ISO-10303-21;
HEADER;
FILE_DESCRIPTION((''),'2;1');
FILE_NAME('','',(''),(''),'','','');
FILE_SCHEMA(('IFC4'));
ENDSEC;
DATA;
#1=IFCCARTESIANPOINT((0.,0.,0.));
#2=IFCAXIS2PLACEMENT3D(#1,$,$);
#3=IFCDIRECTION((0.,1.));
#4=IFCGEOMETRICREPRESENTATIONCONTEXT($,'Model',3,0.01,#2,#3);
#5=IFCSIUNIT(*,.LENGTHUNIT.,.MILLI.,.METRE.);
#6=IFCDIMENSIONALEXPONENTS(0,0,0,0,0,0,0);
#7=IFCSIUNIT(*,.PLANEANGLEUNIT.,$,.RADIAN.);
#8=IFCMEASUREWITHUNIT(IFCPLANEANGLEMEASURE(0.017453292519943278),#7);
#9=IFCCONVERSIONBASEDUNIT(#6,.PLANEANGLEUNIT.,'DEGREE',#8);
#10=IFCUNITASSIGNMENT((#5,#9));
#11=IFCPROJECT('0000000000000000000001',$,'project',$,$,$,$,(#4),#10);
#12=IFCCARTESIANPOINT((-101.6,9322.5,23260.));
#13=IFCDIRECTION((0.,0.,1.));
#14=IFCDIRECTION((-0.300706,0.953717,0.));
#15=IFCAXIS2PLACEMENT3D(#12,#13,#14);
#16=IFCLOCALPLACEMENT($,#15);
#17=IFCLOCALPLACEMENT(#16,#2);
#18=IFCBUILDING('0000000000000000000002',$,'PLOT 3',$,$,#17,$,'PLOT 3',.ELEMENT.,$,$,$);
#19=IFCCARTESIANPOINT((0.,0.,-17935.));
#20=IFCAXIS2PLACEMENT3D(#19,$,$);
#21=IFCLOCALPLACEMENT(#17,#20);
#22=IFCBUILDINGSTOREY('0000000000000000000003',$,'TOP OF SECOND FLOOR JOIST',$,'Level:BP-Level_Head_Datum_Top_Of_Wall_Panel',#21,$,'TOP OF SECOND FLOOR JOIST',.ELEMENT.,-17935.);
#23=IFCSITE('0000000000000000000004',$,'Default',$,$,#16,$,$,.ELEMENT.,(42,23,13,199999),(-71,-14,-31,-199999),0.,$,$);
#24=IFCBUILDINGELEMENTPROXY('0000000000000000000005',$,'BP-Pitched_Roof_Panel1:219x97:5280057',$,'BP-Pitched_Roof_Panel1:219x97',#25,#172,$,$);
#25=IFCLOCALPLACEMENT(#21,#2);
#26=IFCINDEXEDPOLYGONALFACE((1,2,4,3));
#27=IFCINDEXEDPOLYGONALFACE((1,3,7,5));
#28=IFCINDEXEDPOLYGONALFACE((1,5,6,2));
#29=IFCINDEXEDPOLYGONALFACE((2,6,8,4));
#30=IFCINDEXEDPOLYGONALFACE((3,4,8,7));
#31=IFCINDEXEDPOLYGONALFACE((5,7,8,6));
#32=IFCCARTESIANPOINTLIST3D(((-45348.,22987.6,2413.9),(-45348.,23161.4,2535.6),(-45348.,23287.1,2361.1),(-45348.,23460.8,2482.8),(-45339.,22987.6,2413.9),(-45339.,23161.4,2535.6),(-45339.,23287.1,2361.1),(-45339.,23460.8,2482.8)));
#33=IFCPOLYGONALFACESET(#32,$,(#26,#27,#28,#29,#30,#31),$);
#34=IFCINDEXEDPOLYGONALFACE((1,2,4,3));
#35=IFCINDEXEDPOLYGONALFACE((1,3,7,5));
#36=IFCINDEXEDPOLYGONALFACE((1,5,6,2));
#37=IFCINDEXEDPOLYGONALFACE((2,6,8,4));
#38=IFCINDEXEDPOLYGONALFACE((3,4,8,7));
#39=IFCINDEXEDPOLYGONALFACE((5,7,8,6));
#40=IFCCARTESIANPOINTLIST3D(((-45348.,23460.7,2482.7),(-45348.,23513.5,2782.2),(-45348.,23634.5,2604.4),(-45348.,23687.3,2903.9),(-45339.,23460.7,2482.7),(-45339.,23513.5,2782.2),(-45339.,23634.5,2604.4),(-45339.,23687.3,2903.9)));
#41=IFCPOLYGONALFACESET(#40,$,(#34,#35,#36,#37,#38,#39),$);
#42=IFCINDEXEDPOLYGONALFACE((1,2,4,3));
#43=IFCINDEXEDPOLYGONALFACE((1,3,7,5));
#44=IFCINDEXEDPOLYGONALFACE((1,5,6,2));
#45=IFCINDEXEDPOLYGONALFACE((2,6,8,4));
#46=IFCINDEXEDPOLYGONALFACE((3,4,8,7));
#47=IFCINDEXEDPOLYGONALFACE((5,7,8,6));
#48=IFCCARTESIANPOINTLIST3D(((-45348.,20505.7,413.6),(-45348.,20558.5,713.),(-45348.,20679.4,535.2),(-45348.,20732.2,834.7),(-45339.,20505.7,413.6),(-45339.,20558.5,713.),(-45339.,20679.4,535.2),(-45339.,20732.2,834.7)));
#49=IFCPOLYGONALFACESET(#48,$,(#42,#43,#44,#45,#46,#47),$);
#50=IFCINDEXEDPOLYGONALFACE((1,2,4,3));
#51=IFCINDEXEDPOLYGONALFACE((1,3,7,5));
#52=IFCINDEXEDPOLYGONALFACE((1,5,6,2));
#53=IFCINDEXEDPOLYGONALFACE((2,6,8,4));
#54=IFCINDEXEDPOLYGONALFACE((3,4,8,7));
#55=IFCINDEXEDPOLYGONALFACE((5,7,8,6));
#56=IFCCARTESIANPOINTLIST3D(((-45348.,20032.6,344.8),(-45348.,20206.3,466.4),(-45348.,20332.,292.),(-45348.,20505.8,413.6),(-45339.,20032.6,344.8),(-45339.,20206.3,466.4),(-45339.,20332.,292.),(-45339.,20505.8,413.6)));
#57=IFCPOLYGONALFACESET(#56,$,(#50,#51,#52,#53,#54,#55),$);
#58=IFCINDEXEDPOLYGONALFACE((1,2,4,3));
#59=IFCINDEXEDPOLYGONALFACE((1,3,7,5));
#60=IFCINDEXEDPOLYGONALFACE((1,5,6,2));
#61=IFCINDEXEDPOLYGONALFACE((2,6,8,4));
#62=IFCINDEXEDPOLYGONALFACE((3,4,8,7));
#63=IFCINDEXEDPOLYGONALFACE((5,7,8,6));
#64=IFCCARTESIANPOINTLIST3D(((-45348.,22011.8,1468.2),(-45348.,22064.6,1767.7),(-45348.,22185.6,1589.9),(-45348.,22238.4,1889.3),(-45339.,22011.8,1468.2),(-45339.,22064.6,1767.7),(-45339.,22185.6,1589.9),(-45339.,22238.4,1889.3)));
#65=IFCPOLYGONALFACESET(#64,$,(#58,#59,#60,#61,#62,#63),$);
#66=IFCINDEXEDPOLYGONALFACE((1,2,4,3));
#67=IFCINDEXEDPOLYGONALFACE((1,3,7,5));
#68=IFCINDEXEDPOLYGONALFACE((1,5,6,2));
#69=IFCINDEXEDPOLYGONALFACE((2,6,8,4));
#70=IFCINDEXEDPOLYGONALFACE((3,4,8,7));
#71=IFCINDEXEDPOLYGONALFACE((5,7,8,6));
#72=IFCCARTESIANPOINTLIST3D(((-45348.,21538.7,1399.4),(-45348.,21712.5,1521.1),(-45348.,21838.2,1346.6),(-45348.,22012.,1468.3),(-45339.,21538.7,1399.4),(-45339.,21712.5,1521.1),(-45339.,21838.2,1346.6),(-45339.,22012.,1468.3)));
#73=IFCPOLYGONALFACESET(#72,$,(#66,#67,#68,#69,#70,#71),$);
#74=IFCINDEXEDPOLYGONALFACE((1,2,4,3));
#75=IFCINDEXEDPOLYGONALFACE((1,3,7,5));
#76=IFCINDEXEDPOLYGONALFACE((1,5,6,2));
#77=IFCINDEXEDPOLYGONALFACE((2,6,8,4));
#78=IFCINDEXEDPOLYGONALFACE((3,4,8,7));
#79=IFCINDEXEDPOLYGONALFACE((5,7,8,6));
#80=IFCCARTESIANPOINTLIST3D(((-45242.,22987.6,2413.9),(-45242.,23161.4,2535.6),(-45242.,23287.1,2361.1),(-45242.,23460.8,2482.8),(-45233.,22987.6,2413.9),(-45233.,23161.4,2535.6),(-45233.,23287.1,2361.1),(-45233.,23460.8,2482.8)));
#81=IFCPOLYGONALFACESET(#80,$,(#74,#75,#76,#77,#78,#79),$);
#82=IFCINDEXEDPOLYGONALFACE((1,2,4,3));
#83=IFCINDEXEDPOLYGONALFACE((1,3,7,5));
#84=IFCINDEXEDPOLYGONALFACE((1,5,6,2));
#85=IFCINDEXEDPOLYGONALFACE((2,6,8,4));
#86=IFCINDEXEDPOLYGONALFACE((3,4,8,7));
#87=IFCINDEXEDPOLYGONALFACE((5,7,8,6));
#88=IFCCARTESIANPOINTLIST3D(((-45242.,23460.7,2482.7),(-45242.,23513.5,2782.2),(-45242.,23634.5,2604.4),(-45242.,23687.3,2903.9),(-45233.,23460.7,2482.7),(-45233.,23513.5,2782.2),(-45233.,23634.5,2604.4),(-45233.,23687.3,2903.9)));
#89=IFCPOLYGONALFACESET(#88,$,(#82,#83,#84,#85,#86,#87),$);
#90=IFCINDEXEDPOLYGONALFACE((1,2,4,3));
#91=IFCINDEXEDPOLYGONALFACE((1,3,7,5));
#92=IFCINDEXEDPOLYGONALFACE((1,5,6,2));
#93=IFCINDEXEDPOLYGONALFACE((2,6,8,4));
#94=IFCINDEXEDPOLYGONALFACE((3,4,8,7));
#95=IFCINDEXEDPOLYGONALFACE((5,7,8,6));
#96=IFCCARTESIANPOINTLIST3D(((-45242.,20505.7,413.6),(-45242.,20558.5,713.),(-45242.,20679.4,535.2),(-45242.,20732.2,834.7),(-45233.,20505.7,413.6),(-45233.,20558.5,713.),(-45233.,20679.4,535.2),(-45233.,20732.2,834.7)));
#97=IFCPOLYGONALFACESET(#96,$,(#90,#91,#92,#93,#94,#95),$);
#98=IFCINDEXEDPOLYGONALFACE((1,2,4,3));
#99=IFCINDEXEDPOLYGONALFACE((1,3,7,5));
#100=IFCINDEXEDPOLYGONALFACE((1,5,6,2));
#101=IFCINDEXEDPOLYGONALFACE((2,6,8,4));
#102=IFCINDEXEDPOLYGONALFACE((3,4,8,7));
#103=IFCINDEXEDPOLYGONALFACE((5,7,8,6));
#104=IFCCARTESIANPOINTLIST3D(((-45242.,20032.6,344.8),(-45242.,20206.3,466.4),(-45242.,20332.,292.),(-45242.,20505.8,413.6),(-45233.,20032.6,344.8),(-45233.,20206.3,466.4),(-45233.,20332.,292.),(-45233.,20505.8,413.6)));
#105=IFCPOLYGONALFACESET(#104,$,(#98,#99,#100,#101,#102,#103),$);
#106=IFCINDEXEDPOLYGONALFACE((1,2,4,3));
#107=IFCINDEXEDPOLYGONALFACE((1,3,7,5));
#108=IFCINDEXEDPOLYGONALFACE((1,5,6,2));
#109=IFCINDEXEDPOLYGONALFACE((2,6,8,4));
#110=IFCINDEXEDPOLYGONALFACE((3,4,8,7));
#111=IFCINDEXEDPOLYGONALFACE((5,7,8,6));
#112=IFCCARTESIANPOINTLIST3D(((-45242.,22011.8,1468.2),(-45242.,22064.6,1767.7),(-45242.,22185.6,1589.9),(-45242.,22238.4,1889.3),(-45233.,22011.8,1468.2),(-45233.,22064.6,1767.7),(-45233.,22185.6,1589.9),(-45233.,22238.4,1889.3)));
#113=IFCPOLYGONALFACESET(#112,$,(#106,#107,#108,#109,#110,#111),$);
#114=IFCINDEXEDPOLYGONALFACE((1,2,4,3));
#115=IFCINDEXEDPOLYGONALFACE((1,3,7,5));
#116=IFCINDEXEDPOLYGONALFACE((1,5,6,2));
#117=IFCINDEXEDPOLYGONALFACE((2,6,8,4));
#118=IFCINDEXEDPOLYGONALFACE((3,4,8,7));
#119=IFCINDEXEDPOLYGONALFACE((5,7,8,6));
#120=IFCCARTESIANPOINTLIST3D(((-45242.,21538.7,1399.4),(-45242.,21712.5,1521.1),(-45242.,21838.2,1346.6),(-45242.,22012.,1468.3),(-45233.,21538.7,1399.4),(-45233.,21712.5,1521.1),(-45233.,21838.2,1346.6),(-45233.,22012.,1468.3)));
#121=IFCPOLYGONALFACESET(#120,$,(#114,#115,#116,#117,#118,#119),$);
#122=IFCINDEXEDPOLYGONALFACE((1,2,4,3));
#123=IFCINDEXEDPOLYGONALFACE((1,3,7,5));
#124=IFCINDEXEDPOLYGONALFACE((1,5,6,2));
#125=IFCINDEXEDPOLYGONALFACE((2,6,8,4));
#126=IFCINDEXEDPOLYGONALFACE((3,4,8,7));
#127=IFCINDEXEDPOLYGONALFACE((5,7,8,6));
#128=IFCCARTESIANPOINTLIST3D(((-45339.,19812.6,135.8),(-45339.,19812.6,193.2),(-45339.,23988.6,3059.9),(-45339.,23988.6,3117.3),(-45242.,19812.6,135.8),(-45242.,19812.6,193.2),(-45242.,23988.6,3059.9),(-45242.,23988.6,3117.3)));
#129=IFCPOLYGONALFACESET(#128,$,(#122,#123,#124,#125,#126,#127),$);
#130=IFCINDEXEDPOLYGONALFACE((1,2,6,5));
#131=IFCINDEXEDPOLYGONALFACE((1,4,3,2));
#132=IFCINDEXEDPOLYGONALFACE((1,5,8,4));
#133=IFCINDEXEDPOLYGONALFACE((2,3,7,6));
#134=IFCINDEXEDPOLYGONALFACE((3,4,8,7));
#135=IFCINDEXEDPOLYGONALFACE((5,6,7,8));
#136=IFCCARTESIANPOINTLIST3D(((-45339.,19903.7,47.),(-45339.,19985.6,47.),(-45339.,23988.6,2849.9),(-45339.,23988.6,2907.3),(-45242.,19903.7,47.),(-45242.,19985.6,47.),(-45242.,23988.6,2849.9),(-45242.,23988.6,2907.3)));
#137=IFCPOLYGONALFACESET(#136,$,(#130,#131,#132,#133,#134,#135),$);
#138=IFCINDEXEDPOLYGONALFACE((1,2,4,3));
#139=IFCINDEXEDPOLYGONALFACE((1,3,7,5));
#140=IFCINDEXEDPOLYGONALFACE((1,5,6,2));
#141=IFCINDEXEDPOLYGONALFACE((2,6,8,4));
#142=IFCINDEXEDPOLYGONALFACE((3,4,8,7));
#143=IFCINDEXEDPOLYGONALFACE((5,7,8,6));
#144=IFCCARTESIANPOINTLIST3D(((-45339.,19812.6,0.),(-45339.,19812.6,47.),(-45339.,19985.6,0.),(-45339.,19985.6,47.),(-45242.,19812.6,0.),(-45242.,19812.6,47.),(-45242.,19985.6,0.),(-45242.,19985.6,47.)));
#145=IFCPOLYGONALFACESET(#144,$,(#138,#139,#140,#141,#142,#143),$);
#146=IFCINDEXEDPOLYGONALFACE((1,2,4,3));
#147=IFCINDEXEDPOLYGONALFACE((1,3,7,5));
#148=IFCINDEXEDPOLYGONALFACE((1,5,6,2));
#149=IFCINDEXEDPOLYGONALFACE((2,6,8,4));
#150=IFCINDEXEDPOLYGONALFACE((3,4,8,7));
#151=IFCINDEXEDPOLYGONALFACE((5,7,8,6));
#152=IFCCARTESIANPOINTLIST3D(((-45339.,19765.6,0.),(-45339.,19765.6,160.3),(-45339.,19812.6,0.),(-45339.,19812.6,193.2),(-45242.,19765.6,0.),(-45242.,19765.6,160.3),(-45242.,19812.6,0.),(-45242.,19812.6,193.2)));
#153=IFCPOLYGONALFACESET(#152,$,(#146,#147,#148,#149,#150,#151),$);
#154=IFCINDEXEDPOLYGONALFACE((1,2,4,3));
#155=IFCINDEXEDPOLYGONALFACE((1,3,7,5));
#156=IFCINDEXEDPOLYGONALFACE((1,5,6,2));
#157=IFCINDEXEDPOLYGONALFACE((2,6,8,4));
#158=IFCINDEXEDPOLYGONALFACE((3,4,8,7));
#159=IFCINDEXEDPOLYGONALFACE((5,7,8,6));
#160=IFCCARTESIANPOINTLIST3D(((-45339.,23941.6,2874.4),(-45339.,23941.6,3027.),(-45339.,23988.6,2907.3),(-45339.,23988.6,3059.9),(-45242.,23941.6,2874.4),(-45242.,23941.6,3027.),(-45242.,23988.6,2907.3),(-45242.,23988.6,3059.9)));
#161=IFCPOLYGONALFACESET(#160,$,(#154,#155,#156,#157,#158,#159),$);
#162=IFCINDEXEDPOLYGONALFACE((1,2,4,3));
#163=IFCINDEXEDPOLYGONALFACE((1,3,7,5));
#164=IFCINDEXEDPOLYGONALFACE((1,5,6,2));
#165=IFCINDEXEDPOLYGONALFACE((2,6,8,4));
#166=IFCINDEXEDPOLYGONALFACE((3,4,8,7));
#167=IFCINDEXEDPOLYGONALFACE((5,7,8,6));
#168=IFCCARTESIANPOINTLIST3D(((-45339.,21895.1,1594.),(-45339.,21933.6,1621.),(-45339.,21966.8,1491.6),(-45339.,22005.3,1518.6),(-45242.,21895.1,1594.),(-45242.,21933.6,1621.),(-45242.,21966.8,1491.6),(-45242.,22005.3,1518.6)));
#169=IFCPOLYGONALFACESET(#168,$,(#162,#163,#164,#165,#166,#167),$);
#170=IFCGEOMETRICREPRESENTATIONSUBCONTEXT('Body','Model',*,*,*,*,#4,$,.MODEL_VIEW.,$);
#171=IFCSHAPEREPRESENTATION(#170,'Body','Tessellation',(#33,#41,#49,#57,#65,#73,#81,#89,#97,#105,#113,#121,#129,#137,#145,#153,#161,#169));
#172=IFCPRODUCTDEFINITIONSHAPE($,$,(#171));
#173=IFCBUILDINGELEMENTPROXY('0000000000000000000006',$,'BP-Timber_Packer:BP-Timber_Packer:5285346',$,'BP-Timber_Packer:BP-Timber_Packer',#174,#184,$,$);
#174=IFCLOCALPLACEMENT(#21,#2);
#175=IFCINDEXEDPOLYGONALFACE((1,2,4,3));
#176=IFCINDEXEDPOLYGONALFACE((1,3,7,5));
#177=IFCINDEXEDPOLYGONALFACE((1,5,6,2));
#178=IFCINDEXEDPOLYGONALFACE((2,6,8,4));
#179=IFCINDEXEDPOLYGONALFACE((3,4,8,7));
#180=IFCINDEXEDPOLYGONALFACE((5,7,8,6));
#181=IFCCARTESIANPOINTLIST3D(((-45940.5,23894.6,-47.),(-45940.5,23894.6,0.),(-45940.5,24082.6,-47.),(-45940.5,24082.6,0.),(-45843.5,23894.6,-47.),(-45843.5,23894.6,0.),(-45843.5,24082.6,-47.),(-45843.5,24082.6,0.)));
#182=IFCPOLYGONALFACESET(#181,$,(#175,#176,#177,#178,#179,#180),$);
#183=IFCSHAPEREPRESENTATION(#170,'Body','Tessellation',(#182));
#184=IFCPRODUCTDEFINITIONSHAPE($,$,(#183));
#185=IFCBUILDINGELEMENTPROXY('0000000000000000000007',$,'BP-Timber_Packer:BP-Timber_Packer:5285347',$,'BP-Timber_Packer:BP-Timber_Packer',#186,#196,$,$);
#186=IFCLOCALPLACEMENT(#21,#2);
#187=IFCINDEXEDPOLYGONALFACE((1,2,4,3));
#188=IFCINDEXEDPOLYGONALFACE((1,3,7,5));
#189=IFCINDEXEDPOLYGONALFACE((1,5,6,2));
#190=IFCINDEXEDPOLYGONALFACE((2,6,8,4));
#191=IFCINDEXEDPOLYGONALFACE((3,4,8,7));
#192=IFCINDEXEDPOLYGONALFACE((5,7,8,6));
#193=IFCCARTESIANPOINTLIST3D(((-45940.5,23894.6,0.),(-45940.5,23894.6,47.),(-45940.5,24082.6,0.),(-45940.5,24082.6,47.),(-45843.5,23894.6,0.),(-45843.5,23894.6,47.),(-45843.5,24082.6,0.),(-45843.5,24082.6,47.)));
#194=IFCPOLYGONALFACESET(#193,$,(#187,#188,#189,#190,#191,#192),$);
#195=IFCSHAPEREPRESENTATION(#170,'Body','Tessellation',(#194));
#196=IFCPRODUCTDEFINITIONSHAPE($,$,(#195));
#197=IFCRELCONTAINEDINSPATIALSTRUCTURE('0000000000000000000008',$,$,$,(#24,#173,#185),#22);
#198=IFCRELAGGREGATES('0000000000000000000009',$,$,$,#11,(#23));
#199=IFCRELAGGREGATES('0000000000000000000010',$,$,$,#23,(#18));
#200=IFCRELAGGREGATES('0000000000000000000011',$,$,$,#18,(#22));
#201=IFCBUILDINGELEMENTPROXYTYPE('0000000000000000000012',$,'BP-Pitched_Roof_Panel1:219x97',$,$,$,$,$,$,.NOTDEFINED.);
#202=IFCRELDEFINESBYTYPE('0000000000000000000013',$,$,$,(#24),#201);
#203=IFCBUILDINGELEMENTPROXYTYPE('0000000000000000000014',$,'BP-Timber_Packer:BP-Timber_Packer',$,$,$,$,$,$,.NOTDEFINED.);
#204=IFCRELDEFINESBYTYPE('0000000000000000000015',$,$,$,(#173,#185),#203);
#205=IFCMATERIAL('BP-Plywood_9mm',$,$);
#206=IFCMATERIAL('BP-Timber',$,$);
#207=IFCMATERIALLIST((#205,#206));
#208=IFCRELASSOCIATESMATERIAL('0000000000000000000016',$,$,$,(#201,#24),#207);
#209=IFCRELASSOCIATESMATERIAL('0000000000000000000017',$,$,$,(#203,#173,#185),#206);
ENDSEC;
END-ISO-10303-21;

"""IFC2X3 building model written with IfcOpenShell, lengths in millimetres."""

from ifc_helpers import new_model, entity, si_unit, converted_unit, direction, frame, frame_2d, origin, origin_2d_with_axis, place, context, subcontext, project, spatial, polyline, rectangle, outline, extrude, source, transform, mapped, material, material_list, type_object, type_shapes, element, save


model = new_model("IFC2X3")

# Units and contexts
model_context = context("Model", 3, precision=0.01, world=origin(), true_north=direction((0.0, 1.0)))
body_context = subcontext(model_context, "Body", "Model", "MODEL_VIEW")
ifc_project = project(units=[si_unit("LENGTHUNIT", "METRE", prefix="MILLI"), converted_unit("PLANEANGLEUNIT", "DEGREE", entity("IfcPlaneAngleMeasure", 0.017453292519943278), si_unit("PLANEANGLEUNIT", "RADIAN"), dimensions=[0, 0, 0, 0, 0, 0, 0])], contexts=[model_context])

# Site, building, storey
site_placement = place(None, frame((-101.6, 9322.5, 23260.0), z_axis=(0.0, 0.0, 1.0), x_axis=(-0.300706, 0.953717, 0.0)))
site = spatial("IfcSite", under=ifc_project, at=site_placement, Name="Default", CompositionType="ELEMENT", RefLatitude=(42, 23, 13, 199999), RefLongitude=(-71, -14, -31, -199999), RefElevation=0.0)
building_placement = place(site_placement, origin())
building = spatial("IfcBuilding", under=site, at=building_placement, Name="PLOT 3", LongName="PLOT 3", CompositionType="ELEMENT")
storey_placement = place(building_placement, frame((0.0, 0.0, -17935.0)))
storey = spatial("IfcBuildingStorey", under=building, at=storey_placement, Name="TOP OF SECOND FLOOR JOIST", ObjectType="Level:BP-Level_Head_Datum_Top_Of_Wall_Panel", LongName="TOP OF SECOND FLOOR JOIST", CompositionType="ELEMENT", Elevation=-17935.0)

# Building element proxies
ifc_material_1 = material(Name="BP-Timber")
ifc_material_2 = material(Name="BP-Plywood_9mm")
ifc_material_list = material_list([ifc_material_2, ifc_material_1])
building_element_proxy_type_1 = type_object("IfcBuildingElementProxyType", Name="BP-Pitched_Roof_Panel1:219x97", PredefinedType="NOTDEFINED", material=ifc_material_list)
shared_shape_1 = source(origin(), body_context, "Body", "SweptSolid", [
    extrude(outline(polyline([(-77.0, -75.0), (227.0, -75.0), (77.0, 75.0), (-227.0, 75.0), (-77.0, -75.0)])), frame((36.3, 3947.0, 2448.4), z_axis=(0.0, 1.0, 0.0), x_axis=(-0.984808, 0.0, 0.173648)), (0.0, 0.0, 1.0), 9.0),
    extrude(outline(polyline([(1.4, -107.5), (213.6, -107.5), (-1.4, 107.5), (-213.6, 107.5), (1.4, -107.5)])), frame((386.1, 3947.0, 2693.3), z_axis=(0.0, 1.0, 0.0), x_axis=(-0.819152, 0.0, -0.573576)), (0.0, 0.0, 1.0), 9.0),
    extrude(outline(polyline([(1.4, -107.5), (213.6, -107.5), (-1.4, 107.5), (-213.6, 107.5), (1.4, -107.5)])), frame((-2569.0, 3947.0, 624.1), z_axis=(0.0, 1.0, 0.0), x_axis=(-0.819152, 0.0, -0.573576)), (0.0, 0.0, 1.0), 9.0),
    extrude(outline(polyline([(-77.0, -75.0), (227.0, -75.0), (77.0, 75.0), (-227.0, 75.0), (-77.0, -75.0)])), frame((-2918.8, 3947.0, 379.2), z_axis=(0.0, 1.0, 0.0), x_axis=(-0.984808, 0.0, 0.173648)), (0.0, 0.0, 1.0), 9.0),
    extrude(outline(polyline([(1.4, -107.5), (213.6, -107.5), (-1.4, 107.5), (-213.6, 107.5), (1.4, -107.5)])), frame((-1062.8, 3947.0, 1678.8), z_axis=(0.0, 1.0, 0.0), x_axis=(-0.819152, 0.0, -0.573576)), (0.0, 0.0, 1.0), 9.0),
    extrude(outline(polyline([(-77.0, -75.0), (227.0, -75.0), (77.0, 75.0), (-227.0, 75.0), (-77.0, -75.0)])), frame((-1412.6, 3947.0, 1433.9), z_axis=(0.0, 1.0, 0.0), x_axis=(-0.984808, 0.0, 0.173648)), (0.0, 0.0, 1.0), 9.0),
    extrude(outline(polyline([(-77.0, -75.0), (227.0, -75.0), (77.0, 75.0), (-227.0, 75.0), (-77.0, -75.0)])), frame((36.3, 3841.0, 2448.4), z_axis=(0.0, 1.0, 0.0), x_axis=(-0.984808, 0.0, 0.173648)), (0.0, 0.0, 1.0), 9.0),
    extrude(outline(polyline([(1.4, -107.5), (213.6, -107.5), (-1.4, 107.5), (-213.6, 107.5), (1.4, -107.5)])), frame((386.1, 3841.0, 2693.3), z_axis=(0.0, 1.0, 0.0), x_axis=(-0.819152, 0.0, -0.573576)), (0.0, 0.0, 1.0), 9.0),
    extrude(outline(polyline([(1.4, -107.5), (213.6, -107.5), (-1.4, 107.5), (-213.6, 107.5), (1.4, -107.5)])), frame((-2569.0, 3841.0, 624.1), z_axis=(0.0, 1.0, 0.0), x_axis=(-0.819152, 0.0, -0.573576)), (0.0, 0.0, 1.0), 9.0),
    extrude(outline(polyline([(-77.0, -75.0), (227.0, -75.0), (77.0, 75.0), (-227.0, 75.0), (-77.0, -75.0)])), frame((-2918.8, 3841.0, 379.2), z_axis=(0.0, 1.0, 0.0), x_axis=(-0.984808, 0.0, 0.173648)), (0.0, 0.0, 1.0), 9.0),
    extrude(outline(polyline([(1.4, -107.5), (213.6, -107.5), (-1.4, 107.5), (-213.6, 107.5), (1.4, -107.5)])), frame((-1062.8, 3841.0, 1678.8), z_axis=(0.0, 1.0, 0.0), x_axis=(-0.819152, 0.0, -0.573576)), (0.0, 0.0, 1.0), 9.0),
    extrude(outline(polyline([(-77.0, -75.0), (227.0, -75.0), (77.0, 75.0), (-227.0, 75.0), (-77.0, -75.0)])), frame((-1412.6, 3841.0, 1433.9), z_axis=(0.0, 1.0, 0.0), x_axis=(-0.984808, 0.0, 0.173648)), (0.0, 0.0, 1.0), 9.0),
    extrude(outline(polyline([(-1490.7, -2088.0), (-1433.3, -2088.0), (1490.7, 2088.0), (1433.3, 2088.0), (-1490.7, -2088.0)])), frame((-1287.3, 3850.0, 1626.6), z_axis=(0.0, 1.0, 0.0), x_axis=(0.0, 0.0, -1.0)), (0.0, 0.0, 1.0), 97.0),
    extrude(outline(polyline([(-1444.5, -2022.0), (-1387.1, -2022.0), (1415.8, 1981.0), (1415.8, 2063.0), (-1444.5, -2022.0)])), frame((-1221.3, 3850.0, 1462.8), z_axis=(0.0, 1.0, 0.0), x_axis=(0.0, 0.0, -1.0)), (0.0, 0.0, 1.0), 97.0),
    extrude(rectangle(XDim=97.0, YDim=173.0, at=origin_2d_with_axis()), frame((-3288.8, 3898.5, 0.0), z_axis=(0.0, 0.0, 1.0), x_axis=(0.0, 1.0, 0.0)), (0.0, 0.0, 1.0), 47.0),
    extrude(outline(polyline([(22.0, -72.4), (79.4, -72.4), (-31.4, 85.9), (-69.9, 58.9), (22.0, -72.4)])), frame((-3398.8, 3850.0, 88.4), z_axis=(0.0, 1.0, 0.0), x_axis=(0.819152, 0.0, 0.573576)), (0.0, 0.0, 1.0), 97.0),
    extrude(outline(polyline([(15.1, -62.5), (72.5, -62.5), (-15.1, 62.5), (-72.5, 62.5), (15.1, -62.5)])), frame((777.2, 3850.0, 2967.2), z_axis=(0.0, 1.0, 0.0), x_axis=(0.819152, 0.0, 0.573576)), (0.0, 0.0, 1.0), 97.0),
    extrude(rectangle(XDim=47.0, YDim=97.0, at=frame_2d((0.0, 0.0), x_axis=(0.0, 1.0))), frame((-1201.9, 3898.5, 1505.1), z_axis=(-0.573576, 0.0, 0.819152), x_axis=(0.0, 1.0, 0.0)), (0.0, 0.0, 1.0), 125.0),
])
type_shapes(building_element_proxy_type_1, [shared_shape_1])
for number, where, z_axis, x_axis, name in (
    (1, (-41392.0, 23187.9, 0.0), (0.0, 0.0, 1.0), (0.0, 1.0, 0.0), "BP-Pitched_Roof_Panel1:219x97:5280057"),
):
    element("IfcBuildingElementProxy", number, at=place(storey_placement, frame(where, z_axis=z_axis, x_axis=x_axis)), inside=storey, type_object=building_element_proxy_type_1, material=ifc_material_list, Name=name, ObjectType="BP-Pitched_Roof_Panel1:219x97", context=body_context, shape_type="MappedRepresentation", body=[
        mapped(shared_shape_1, transform((0.0, 0.0, 0.0), scale=1.0)),
    ])
building_element_proxy_type_2 = type_object("IfcBuildingElementProxyType", Name="BP-Timber_Packer:BP-Timber_Packer", PredefinedType="NOTDEFINED", material=ifc_material_1)
shared_shape_2 = source(origin(), body_context, "Body", "SweptSolid", [
    extrude(rectangle(XDim=97.0, YDim=188.0, at=origin_2d_with_axis()), frame((0.0, 0.0, 0.0), z_axis=(0.0, 0.0, 1.0), x_axis=(0.0, 1.0, 0.0)), (0.0, 0.0, 1.0), 47.0),
])
type_shapes(building_element_proxy_type_2, [shared_shape_2])
for number, where, z_axis, x_axis, name in (
    (2, (-45892.0, 23988.6, -47.0), (0.0, 0.0, 1.0), (0.0, 1.0, 0.0), "BP-Timber_Packer:BP-Timber_Packer:5285346"),
    (3, (-45892.0, 23988.6, 0.0), (0.0, 0.0, 1.0), (0.0, 1.0, 0.0), "BP-Timber_Packer:BP-Timber_Packer:5285347"),
):
    element("IfcBuildingElementProxy", number, at=place(storey_placement, frame(where, z_axis=z_axis, x_axis=x_axis)), inside=storey, type_object=building_element_proxy_type_2, material=ifc_material_1, Name=name, ObjectType="BP-Timber_Packer:BP-Timber_Packer", context=body_context, shape_type="MappedRepresentation", body=[
        mapped(shared_shape_2, transform((0.0, 0.0, 0.0), scale=1.0)),
    ])

save(model, "model.ifc")
